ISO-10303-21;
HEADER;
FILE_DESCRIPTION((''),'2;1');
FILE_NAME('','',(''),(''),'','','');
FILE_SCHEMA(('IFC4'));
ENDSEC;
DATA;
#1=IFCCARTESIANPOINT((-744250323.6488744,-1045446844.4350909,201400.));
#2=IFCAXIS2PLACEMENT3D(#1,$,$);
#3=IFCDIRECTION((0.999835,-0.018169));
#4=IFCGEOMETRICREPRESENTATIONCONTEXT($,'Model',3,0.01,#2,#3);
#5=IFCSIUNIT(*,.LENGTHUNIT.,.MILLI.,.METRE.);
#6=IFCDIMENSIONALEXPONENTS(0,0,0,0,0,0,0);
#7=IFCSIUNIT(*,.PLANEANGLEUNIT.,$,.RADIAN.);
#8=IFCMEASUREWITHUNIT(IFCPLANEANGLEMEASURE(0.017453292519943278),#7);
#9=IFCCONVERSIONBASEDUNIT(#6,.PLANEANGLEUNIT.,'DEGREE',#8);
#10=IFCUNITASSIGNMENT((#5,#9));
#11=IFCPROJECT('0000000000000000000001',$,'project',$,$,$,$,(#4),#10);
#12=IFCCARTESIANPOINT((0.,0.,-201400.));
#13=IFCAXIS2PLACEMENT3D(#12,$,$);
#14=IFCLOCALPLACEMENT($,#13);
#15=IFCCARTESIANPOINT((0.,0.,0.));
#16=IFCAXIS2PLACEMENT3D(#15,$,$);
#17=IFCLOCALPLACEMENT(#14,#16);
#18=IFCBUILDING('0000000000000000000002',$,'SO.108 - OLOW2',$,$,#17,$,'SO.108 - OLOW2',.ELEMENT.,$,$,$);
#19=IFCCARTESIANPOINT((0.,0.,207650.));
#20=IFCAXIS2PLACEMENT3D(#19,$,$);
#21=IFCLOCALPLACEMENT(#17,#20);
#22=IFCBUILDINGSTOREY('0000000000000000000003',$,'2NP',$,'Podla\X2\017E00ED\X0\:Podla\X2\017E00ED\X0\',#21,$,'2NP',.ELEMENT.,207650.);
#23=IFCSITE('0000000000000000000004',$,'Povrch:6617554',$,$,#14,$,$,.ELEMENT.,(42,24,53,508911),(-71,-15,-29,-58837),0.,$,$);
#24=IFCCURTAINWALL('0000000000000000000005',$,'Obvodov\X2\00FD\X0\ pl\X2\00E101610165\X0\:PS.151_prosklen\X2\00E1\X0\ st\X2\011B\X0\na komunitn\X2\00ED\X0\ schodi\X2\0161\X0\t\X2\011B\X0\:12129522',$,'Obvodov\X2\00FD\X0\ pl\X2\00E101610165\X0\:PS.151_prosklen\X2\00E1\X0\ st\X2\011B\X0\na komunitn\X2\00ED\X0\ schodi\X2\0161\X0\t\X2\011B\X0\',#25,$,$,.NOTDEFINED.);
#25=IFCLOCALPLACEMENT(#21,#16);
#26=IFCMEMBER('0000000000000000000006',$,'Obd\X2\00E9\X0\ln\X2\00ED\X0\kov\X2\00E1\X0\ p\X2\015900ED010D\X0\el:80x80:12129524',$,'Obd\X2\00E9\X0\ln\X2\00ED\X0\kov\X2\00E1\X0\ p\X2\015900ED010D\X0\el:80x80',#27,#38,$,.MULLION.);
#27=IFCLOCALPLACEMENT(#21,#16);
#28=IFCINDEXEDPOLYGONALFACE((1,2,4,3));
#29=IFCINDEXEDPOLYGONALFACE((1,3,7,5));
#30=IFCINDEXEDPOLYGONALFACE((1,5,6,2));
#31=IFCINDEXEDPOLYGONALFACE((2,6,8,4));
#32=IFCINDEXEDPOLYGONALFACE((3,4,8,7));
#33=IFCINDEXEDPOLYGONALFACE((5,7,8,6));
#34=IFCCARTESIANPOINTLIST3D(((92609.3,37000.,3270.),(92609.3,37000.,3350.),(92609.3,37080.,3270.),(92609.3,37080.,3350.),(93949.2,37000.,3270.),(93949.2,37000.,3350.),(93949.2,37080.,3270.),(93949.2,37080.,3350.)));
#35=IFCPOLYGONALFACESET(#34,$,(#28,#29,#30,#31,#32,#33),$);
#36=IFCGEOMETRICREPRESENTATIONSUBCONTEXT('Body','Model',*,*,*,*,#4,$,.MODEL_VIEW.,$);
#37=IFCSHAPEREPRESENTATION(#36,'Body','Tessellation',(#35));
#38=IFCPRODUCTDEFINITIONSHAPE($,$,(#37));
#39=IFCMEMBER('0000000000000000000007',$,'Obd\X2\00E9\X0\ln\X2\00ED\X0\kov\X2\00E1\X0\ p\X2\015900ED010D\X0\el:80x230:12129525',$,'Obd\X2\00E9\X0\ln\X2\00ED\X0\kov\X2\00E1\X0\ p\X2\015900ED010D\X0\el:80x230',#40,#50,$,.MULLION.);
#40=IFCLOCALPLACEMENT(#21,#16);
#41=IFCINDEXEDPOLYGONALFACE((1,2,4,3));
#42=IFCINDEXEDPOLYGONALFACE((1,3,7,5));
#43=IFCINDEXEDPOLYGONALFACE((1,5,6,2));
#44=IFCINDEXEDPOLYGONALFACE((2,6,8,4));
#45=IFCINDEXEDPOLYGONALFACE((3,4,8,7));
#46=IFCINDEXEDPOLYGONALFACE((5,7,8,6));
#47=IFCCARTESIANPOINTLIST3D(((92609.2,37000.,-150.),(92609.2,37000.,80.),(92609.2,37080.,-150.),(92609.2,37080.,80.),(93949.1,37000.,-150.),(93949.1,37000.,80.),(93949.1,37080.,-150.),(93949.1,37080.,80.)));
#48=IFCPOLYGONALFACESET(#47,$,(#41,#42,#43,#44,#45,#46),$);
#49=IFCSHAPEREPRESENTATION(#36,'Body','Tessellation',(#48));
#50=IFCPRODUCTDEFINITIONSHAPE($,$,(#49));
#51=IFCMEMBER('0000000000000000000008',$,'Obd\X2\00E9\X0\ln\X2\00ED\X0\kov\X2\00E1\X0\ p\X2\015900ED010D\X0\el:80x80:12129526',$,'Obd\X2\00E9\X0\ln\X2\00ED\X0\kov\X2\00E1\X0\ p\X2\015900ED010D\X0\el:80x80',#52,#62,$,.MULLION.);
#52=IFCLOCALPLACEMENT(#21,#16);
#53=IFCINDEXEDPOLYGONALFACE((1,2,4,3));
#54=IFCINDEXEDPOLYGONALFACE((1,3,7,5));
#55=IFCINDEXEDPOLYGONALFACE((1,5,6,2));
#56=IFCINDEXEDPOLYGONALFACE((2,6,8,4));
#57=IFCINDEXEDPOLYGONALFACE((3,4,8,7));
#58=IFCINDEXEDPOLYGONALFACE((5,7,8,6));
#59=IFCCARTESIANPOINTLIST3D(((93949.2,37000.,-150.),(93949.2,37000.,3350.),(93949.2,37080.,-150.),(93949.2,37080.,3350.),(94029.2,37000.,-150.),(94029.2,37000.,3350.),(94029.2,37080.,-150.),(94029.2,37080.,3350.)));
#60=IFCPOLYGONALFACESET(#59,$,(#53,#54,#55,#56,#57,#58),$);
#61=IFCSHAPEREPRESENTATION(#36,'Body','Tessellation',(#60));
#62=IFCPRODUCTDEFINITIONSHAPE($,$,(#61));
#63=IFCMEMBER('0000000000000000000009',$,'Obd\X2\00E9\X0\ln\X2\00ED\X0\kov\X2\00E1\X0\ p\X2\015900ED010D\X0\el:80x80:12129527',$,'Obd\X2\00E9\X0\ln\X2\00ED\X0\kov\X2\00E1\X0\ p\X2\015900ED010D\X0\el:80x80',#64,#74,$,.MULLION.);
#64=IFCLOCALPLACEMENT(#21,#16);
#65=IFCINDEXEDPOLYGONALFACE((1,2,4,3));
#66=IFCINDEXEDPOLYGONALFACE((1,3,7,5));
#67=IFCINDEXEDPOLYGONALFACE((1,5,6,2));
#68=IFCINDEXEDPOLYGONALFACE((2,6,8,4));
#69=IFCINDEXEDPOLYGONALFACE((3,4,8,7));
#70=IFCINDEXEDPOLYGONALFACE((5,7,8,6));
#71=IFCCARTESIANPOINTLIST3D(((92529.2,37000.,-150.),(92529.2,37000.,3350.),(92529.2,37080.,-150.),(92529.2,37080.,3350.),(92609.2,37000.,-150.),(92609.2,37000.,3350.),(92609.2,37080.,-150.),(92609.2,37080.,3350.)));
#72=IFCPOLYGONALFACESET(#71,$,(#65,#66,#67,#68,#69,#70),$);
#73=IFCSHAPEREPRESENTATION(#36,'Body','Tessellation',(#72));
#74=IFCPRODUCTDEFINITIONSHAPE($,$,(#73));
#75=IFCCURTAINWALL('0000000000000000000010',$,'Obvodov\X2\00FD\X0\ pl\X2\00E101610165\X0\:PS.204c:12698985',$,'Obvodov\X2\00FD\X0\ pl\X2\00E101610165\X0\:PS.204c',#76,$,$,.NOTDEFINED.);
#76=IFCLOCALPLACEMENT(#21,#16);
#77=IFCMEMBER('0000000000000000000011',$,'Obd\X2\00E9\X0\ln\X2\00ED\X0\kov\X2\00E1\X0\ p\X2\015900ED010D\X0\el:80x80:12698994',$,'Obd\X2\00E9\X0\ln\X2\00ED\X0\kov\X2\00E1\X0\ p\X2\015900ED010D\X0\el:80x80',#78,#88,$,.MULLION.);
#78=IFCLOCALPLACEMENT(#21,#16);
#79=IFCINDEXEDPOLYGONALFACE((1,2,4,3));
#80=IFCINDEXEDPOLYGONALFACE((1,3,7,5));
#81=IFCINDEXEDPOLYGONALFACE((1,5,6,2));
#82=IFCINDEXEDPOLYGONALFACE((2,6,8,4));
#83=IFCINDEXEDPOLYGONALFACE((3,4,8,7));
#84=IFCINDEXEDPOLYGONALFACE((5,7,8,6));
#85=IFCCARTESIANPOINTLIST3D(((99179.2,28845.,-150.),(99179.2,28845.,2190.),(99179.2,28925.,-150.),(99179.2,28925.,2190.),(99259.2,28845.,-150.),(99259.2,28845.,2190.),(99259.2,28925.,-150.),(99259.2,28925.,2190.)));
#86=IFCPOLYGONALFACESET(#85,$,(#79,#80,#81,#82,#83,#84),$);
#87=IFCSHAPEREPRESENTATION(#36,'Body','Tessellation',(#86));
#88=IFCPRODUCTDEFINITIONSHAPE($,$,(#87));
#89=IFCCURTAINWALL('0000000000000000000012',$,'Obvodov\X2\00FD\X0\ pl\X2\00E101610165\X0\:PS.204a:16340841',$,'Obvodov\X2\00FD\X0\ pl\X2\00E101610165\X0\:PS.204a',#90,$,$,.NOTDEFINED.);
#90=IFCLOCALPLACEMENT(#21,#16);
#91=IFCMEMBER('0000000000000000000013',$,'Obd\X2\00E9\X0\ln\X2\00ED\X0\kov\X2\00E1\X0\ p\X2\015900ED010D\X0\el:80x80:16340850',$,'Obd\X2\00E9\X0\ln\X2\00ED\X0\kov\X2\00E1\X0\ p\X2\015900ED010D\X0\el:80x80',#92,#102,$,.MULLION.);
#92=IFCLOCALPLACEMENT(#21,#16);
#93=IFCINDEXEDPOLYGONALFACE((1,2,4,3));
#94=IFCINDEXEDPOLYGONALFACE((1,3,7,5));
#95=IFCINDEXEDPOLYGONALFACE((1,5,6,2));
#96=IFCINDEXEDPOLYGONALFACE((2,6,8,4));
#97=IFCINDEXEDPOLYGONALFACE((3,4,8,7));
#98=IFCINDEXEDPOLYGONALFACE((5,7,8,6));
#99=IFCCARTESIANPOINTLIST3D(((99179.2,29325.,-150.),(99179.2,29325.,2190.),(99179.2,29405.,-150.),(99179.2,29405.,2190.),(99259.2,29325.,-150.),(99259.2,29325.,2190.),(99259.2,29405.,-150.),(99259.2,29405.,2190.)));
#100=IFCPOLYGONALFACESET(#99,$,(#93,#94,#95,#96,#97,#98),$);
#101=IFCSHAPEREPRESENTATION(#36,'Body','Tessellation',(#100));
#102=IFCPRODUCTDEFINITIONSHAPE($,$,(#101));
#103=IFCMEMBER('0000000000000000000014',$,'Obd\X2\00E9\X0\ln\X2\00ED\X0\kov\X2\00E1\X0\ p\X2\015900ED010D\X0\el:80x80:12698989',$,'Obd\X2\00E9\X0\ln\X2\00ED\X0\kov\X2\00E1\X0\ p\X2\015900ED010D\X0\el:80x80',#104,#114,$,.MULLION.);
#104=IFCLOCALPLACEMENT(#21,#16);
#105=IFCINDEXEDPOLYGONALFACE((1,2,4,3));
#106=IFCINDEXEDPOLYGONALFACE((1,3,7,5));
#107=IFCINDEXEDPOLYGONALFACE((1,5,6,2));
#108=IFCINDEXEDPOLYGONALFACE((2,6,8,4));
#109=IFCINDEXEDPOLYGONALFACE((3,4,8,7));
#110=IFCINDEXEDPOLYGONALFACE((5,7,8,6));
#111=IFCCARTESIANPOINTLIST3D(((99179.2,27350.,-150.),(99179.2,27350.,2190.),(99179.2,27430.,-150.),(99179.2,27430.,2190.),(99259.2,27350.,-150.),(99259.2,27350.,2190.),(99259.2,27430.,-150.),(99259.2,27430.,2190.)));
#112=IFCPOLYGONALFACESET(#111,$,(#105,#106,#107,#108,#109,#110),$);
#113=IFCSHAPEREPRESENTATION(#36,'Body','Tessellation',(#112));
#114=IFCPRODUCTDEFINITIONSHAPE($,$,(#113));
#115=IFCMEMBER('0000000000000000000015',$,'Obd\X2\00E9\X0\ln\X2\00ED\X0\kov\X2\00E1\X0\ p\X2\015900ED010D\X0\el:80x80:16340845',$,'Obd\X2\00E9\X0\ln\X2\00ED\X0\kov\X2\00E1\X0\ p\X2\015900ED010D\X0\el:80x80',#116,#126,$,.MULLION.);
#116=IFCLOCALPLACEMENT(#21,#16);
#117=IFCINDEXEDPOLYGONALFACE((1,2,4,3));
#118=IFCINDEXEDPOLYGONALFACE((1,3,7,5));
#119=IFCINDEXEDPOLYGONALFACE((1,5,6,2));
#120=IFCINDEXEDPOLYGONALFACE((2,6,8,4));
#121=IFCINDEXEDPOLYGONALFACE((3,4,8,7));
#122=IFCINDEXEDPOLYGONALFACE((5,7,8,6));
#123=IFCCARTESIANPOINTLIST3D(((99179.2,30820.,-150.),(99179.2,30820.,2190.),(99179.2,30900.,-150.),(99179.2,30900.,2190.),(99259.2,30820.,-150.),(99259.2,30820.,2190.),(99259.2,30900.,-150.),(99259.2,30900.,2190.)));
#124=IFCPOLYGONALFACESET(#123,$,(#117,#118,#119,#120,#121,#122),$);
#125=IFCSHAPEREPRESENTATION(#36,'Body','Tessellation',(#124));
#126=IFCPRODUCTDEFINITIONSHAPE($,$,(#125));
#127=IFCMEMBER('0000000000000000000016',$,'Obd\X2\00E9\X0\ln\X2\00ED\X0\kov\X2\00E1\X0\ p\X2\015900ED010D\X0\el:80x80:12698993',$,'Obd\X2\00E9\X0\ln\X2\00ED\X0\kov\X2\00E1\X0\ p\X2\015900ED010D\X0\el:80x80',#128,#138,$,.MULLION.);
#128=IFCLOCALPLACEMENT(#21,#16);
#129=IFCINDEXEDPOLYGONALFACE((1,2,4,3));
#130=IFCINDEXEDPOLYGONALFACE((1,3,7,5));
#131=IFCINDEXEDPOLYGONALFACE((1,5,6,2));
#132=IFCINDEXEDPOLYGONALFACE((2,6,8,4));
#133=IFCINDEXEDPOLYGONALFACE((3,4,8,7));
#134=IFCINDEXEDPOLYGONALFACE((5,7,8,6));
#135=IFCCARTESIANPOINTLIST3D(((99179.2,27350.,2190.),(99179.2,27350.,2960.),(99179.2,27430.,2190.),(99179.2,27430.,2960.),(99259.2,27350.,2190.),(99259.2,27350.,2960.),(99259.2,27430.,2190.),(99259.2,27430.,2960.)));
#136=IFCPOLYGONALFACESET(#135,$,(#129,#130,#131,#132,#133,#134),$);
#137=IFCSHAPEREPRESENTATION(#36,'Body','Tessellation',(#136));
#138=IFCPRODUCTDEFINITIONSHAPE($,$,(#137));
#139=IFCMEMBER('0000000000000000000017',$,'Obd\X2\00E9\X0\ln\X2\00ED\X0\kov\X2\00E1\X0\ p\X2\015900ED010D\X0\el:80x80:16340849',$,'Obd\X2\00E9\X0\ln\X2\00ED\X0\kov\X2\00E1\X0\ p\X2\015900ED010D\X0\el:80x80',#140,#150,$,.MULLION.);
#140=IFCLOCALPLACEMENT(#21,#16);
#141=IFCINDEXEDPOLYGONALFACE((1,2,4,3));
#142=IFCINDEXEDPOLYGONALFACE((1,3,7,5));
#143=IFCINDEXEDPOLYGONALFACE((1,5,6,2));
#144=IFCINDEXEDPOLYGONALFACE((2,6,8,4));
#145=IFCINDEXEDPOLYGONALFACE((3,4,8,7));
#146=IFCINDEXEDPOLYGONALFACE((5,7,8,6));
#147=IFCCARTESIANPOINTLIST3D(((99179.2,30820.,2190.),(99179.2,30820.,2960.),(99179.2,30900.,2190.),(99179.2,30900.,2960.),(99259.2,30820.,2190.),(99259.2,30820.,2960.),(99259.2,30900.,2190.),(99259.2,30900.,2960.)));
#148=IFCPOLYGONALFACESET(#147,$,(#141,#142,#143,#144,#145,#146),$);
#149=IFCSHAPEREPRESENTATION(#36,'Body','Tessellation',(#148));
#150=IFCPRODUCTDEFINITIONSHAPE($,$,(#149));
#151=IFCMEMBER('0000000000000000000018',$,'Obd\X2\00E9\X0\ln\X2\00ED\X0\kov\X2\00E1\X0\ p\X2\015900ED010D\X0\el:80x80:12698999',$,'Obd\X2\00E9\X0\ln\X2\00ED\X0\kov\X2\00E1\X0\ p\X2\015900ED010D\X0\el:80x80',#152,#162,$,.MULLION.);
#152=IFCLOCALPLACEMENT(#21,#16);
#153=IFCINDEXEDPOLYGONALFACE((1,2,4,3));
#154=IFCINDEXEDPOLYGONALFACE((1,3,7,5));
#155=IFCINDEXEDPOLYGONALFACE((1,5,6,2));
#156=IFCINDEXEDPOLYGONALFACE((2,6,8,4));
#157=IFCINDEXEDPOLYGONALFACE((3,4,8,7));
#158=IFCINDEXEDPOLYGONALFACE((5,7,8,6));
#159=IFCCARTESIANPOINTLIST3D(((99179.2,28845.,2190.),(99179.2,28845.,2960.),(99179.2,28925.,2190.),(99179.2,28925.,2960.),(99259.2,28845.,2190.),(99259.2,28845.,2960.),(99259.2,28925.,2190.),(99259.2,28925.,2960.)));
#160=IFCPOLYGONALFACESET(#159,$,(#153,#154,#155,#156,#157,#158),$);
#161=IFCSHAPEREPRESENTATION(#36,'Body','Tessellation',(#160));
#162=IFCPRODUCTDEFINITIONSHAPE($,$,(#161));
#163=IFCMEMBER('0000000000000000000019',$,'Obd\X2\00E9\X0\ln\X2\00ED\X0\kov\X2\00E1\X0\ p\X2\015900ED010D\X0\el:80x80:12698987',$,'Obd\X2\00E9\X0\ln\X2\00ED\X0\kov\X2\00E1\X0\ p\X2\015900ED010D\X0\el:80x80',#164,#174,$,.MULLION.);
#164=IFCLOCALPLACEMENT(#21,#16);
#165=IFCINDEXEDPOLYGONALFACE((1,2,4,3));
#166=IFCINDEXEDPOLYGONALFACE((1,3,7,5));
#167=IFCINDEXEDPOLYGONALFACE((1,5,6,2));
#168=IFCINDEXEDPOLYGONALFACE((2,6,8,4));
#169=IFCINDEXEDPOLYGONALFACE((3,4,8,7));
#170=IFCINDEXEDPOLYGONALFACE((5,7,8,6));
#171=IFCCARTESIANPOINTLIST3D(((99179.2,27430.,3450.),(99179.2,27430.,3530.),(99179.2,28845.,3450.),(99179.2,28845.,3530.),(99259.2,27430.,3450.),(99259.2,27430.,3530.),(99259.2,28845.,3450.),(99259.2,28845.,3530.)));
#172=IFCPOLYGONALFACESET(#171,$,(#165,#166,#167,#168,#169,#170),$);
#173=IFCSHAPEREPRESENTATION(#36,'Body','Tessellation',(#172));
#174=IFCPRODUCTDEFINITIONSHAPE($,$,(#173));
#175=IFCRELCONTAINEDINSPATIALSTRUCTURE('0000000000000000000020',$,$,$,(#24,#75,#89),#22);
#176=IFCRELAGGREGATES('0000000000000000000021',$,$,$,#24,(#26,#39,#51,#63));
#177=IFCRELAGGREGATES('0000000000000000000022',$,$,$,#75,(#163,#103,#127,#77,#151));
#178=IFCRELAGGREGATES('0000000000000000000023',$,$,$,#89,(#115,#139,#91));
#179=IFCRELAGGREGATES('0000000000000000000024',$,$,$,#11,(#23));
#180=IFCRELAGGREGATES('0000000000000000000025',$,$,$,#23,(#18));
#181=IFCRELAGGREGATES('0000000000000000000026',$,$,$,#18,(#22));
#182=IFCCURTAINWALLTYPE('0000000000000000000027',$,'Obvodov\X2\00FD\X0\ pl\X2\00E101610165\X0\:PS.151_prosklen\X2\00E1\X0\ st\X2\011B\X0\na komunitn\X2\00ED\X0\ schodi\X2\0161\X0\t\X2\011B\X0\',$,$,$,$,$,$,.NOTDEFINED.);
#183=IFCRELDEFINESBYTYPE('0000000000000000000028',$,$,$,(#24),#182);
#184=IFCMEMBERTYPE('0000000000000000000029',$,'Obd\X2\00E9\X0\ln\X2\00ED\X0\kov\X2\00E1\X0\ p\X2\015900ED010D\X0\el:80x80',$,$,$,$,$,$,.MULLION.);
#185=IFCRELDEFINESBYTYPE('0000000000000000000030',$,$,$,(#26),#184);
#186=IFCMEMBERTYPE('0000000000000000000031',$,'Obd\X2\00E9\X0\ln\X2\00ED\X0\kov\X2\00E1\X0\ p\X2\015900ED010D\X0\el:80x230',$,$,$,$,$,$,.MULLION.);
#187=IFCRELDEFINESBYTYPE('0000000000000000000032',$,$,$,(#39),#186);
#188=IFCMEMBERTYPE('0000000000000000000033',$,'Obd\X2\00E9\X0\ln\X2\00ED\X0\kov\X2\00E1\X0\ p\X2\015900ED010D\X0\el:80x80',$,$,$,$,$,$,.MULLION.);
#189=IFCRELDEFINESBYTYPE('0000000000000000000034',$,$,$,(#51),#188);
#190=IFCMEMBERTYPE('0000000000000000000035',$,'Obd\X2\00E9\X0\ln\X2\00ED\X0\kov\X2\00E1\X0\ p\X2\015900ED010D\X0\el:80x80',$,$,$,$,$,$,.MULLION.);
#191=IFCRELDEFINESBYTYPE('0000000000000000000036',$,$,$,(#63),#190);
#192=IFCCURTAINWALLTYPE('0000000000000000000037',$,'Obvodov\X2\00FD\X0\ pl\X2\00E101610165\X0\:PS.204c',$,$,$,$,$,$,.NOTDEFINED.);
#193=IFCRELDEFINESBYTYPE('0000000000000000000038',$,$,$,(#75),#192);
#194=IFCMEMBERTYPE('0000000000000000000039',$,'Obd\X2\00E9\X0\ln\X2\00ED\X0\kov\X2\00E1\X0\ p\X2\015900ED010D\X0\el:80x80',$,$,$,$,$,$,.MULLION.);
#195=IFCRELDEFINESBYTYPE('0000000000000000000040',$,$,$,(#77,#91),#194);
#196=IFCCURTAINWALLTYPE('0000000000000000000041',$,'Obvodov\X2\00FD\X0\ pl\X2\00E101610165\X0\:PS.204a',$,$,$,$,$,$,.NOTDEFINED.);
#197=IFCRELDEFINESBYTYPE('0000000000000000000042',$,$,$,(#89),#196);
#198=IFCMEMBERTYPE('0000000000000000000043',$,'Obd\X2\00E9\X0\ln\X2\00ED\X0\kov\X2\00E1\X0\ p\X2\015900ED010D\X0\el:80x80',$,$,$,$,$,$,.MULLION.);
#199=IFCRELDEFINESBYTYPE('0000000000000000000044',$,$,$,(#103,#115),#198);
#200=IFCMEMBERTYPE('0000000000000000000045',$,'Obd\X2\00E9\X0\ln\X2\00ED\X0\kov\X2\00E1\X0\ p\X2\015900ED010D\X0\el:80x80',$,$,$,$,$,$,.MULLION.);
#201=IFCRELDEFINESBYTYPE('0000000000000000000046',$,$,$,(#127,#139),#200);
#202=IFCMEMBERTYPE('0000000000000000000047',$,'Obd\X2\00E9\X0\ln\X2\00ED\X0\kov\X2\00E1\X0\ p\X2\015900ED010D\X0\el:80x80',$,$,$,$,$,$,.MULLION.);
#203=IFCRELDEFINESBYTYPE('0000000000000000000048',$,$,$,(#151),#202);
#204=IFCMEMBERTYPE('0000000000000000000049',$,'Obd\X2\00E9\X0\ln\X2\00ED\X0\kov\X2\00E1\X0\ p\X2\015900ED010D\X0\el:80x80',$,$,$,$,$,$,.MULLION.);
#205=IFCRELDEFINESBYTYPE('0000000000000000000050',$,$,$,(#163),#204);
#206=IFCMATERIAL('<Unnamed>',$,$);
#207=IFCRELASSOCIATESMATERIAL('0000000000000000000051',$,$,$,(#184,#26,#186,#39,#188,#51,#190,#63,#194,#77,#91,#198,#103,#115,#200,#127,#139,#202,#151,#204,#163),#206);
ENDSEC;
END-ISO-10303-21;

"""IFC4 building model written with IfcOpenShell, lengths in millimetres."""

from ifc_helpers import new_model, entity, si_unit, converted_unit, direction, frame, origin, place, context, subcontext, project, spatial, indexed_curve, outline, extrude, source, transform, mapped, material, type_object, type_shapes, element, aggregate, save


model = new_model("IFC4")

# Units and contexts
model_context = context("Model", 3, precision=0.01, world=frame((-744250323.6488744, -1045446844.4350909, 201400.0)), true_north=direction((0.999835, -0.018169)))
body_context = subcontext(model_context, "Body", "Model", "MODEL_VIEW")
ifc_project = project(units=[si_unit("LENGTHUNIT", "METRE", prefix="MILLI"), converted_unit("PLANEANGLEUNIT", "DEGREE", entity("IfcPlaneAngleMeasure", 0.017453292519943278), si_unit("PLANEANGLEUNIT", "RADIAN"), dimensions=[0, 0, 0, 0, 0, 0, 0])], contexts=[model_context])

# Site, building, storey
site_placement = place(None, frame((0.0, 0.0, -201400.0)))
site = spatial("IfcSite", under=ifc_project, at=site_placement, Name="Povrch:6617554", CompositionType="ELEMENT", RefLatitude=(42, 24, 53, 508911), RefLongitude=(-71, -15, -29, -58837), RefElevation=0.0)
building_placement = place(site_placement, origin())
building = spatial("IfcBuilding", under=site, at=building_placement, Name="SO.108 - OLOW2", LongName="SO.108 - OLOW2", CompositionType="ELEMENT")
storey_placement = place(building_placement, frame((0.0, 0.0, 207650.0)))
storey = spatial("IfcBuildingStorey", under=building, at=storey_placement, Name="2NP", ObjectType="Podlaží:Podlaží", LongName="2NP", CompositionType="ELEMENT", Elevation=207650.0)

# Curtain wall, members
curtain_wall_type_1 = type_object("IfcCurtainWallType", Name="Obvodový plášť:PS.151_prosklená stěna komunitní schodiště", PredefinedType="NOTDEFINED")
curtain_wall_1_placement = place(storey_placement, frame((0.0, 0.0, -207650.0)))
curtain_wall_1 = element("IfcCurtainWall", 1, at=curtain_wall_1_placement, inside=storey, type_object=curtain_wall_type_1, Name="Obvodový plášť:PS.151_prosklená stěna komunitní schodiště:12129522", ObjectType="Obvodový plášť:PS.151_prosklená stěna komunitní schodiště", PredefinedType="NOTDEFINED")
ifc_material_1 = material(Name="<Unnamed>")
member_type_1 = type_object("IfcMemberType", Name="Obdélníková příčel:80x80", PredefinedType="MULLION", material=ifc_material_1)
shared_shape_1 = source(origin(), body_context, "Body", "SweptSolid", [
    extrude(outline(indexed_curve([(-40.0, -40.0), (40.0, -40.0), (40.0, 40.0), (-40.0, 40.0), (-40.0, -40.0)], self_intersect=False)), frame((-40.0, 0.0, -1339.9), z_axis=(0.0, 0.0, 1.0), x_axis=(-1.0, 0.0, 0.0)), (0.0, 0.0, 1.0), 1339.9),
])
type_shapes(member_type_1, [shared_shape_1])
member_1_placement = place(curtain_wall_1_placement, frame((93949.2, 37040.0, 211000.0), z_axis=(1.0, 0.0, 0.0), x_axis=(0.0, 0.0, 1.0)))
member_1 = element("IfcMember", 2, at=member_1_placement, type_object=member_type_1, material=ifc_material_1, Name="Obdélníková příčel:80x80:12129524", ObjectType="Obdélníková příčel:80x80", PredefinedType="MULLION", context=body_context, shape_type="MappedRepresentation", body=[
    mapped(shared_shape_1, transform((0.0, 0.0, 0.0), scale=1.0)),
])
member_type_2 = type_object("IfcMemberType", Name="Obdélníková příčel:80x230", PredefinedType="MULLION", material=ifc_material_1)
shared_shape_2 = source(origin(), body_context, "Body", "SweptSolid", [
    extrude(outline(indexed_curve([(-115.0, -40.0), (115.0, -40.0), (115.0, 40.0), (-115.0, 40.0), (-115.0, -40.0)], self_intersect=False)), frame((-115.0, 0.0, -1339.9), z_axis=(0.0, 0.0, 1.0), x_axis=(-1.0, 0.0, 0.0)), (0.0, 0.0, 1.0), 1339.9),
])
type_shapes(member_type_2, [shared_shape_2])
member_2_placement = place(curtain_wall_1_placement, frame((92609.2, 37040.0, 207500.0), z_axis=(-1.0, 0.0, 0.0), x_axis=(0.0, 0.0, -1.0)))
member_2 = element("IfcMember", 3, at=member_2_placement, type_object=member_type_2, material=ifc_material_1, Name="Obdélníková příčel:80x230:12129525", ObjectType="Obdélníková příčel:80x230", PredefinedType="MULLION", context=body_context, shape_type="MappedRepresentation", body=[
    mapped(shared_shape_2, transform((0.0, 0.0, 0.0), scale=1.0)),
])
member_type_3 = type_object("IfcMemberType", Name="Obdélníková příčel:80x80", PredefinedType="MULLION", material=ifc_material_1)
shared_shape_3 = source(origin(), body_context, "Body", "SweptSolid", [
    extrude(outline(indexed_curve([(-40.0, -40.0), (40.0, -40.0), (40.0, 40.0), (-40.0, 40.0), (-40.0, -40.0)], self_intersect=False)), frame((-40.0, 0.0, -3500.0), z_axis=(0.0, 0.0, 1.0), x_axis=(-1.0, 0.0, 0.0)), (0.0, 0.0, 1.0), 3500.0),
])
type_shapes(member_type_3, [shared_shape_3])
member_3_placement = place(curtain_wall_1_placement, frame((94029.2, 37040.0, 207500.0), z_axis=(0.0, 0.0, -1.0), x_axis=(1.0, 0.0, 0.0)))
member_3 = element("IfcMember", 4, at=member_3_placement, type_object=member_type_3, material=ifc_material_1, Name="Obdélníková příčel:80x80:12129526", ObjectType="Obdélníková příčel:80x80", PredefinedType="MULLION", context=body_context, shape_type="MappedRepresentation", body=[
    mapped(shared_shape_3, transform((0.0, 0.0, 0.0), scale=1.0)),
])
member_type_4 = type_object("IfcMemberType", Name="Obdélníková příčel:80x80", PredefinedType="MULLION", material=ifc_material_1)
shared_shape_4 = source(origin(), body_context, "Body", "SweptSolid", [
    extrude(outline(indexed_curve([(-40.0, -40.0), (40.0, -40.0), (40.0, 40.0), (-40.0, 40.0), (-40.0, -40.0)], self_intersect=False)), frame((-40.0, 0.0, -3500.0), z_axis=(0.0, 0.0, 1.0), x_axis=(-1.0, 0.0, 0.0)), (0.0, 0.0, 1.0), 3500.0),
])
type_shapes(member_type_4, [shared_shape_4])
member_4_placement = place(curtain_wall_1_placement, frame((92529.2, 37040.0, 211000.0), z_axis=(0.0, 0.0, 1.0), x_axis=(-1.0, 0.0, 0.0)))
member_4 = element("IfcMember", 5, at=member_4_placement, type_object=member_type_4, material=ifc_material_1, Name="Obdélníková příčel:80x80:12129527", ObjectType="Obdélníková příčel:80x80", PredefinedType="MULLION", context=body_context, shape_type="MappedRepresentation", body=[
    mapped(shared_shape_4, transform((0.0, 0.0, 0.0), scale=1.0)),
])

# Curtain walls, members
curtain_wall_type_2 = type_object("IfcCurtainWallType", Name="Obvodový plášť:PS.204c", PredefinedType="NOTDEFINED")
curtain_wall_2_placement = place(storey_placement, frame((0.0, 0.0, -207650.0)))
curtain_wall_2 = element("IfcCurtainWall", 6, at=curtain_wall_2_placement, inside=storey, type_object=curtain_wall_type_2, Name="Obvodový plášť:PS.204c:12698985", ObjectType="Obvodový plášť:PS.204c", PredefinedType="NOTDEFINED")
member_type_5 = type_object("IfcMemberType", Name="Obdélníková příčel:80x80", PredefinedType="MULLION", material=ifc_material_1)
shared_shape_5 = source(origin(), body_context, "Body", "SweptSolid", [
    extrude(outline(indexed_curve([(-40.0, -40.0), (40.0, -40.0), (40.0, 40.0), (-40.0, 40.0), (-40.0, -40.0)], self_intersect=False)), frame((-40.0, 0.0, -2340.0), z_axis=(0.0, 0.0, 1.0), x_axis=(-1.0, 0.0, 0.0)), (0.0, 0.0, 1.0), 2340.0),
])
type_shapes(member_type_5, [shared_shape_5])
member_5_placement = place(curtain_wall_2_placement, frame((99219.2, 28925.0, 209840.0), z_axis=(0.0, 0.0, 1.0), x_axis=(0.0, 1.0, 0.0)))
member_5 = element("IfcMember", 7, at=member_5_placement, type_object=member_type_5, material=ifc_material_1, Name="Obdélníková příčel:80x80:12698994", ObjectType="Obdélníková příčel:80x80", PredefinedType="MULLION", context=body_context, shape_type="MappedRepresentation", body=[
    mapped(shared_shape_5, transform((0.0, 0.0, 0.0), scale=1.0)),
])
curtain_wall_type_3 = type_object("IfcCurtainWallType", Name="Obvodový plášť:PS.204a", PredefinedType="NOTDEFINED")
curtain_wall_3_placement = place(storey_placement, frame((0.0, 0.0, -207650.0)))
curtain_wall_3 = element("IfcCurtainWall", 8, at=curtain_wall_3_placement, inside=storey, type_object=curtain_wall_type_3, Name="Obvodový plášť:PS.204a:16340841", ObjectType="Obvodový plášť:PS.204a", PredefinedType="NOTDEFINED")
member_6_placement = place(curtain_wall_3_placement, frame((99219.2, 29325.0, 209840.0), z_axis=(0.0, 0.0, 1.0), x_axis=(0.0, -1.0, 0.0)))
member_6 = element("IfcMember", 9, at=member_6_placement, type_object=member_type_5, material=ifc_material_1, Name="Obdélníková příčel:80x80:16340850", ObjectType="Obdélníková příčel:80x80", PredefinedType="MULLION", context=body_context, shape_type="MappedRepresentation", body=[
    mapped(shared_shape_5, transform((0.0, 0.0, 0.0), scale=1.0)),
])

# Members
member_type_6 = type_object("IfcMemberType", Name="Obdélníková příčel:80x80", PredefinedType="MULLION", material=ifc_material_1)
shared_shape_6 = source(origin(), body_context, "Body", "SweptSolid", [
    extrude(outline(indexed_curve([(-40.0, -40.0), (40.0, -40.0), (40.0, 40.0), (-40.0, 40.0), (-40.0, -40.0)], self_intersect=False)), frame((-40.0, 0.0, -2340.0), z_axis=(0.0, 0.0, 1.0), x_axis=(-1.0, 0.0, 0.0)), (0.0, 0.0, 1.0), 2340.0),
])
type_shapes(member_type_6, [shared_shape_6])
member_7_placement = place(curtain_wall_2_placement, frame((99219.2, 27350.0, 207500.0), z_axis=(0.0, 0.0, -1.0), x_axis=(0.0, -1.0, 0.0)))
member_7 = element("IfcMember", 10, at=member_7_placement, type_object=member_type_6, material=ifc_material_1, Name="Obdélníková příčel:80x80:12698989", ObjectType="Obdélníková příčel:80x80", PredefinedType="MULLION", context=body_context, shape_type="MappedRepresentation", body=[
    mapped(shared_shape_6, transform((0.0, 0.0, 0.0), scale=1.0)),
])
member_8_placement = place(curtain_wall_3_placement, frame((99219.2, 30900.0, 207500.0), z_axis=(0.0, 0.0, -1.0), x_axis=(0.0, 1.0, 0.0)))
member_8 = element("IfcMember", 11, at=member_8_placement, type_object=member_type_6, material=ifc_material_1, Name="Obdélníková příčel:80x80:16340845", ObjectType="Obdélníková příčel:80x80", PredefinedType="MULLION", context=body_context, shape_type="MappedRepresentation", body=[
    mapped(shared_shape_6, transform((0.0, 0.0, 0.0), scale=1.0)),
])
member_type_7 = type_object("IfcMemberType", Name="Obdélníková příčel:80x80", PredefinedType="MULLION", material=ifc_material_1)
shared_shape_7 = source(origin(), body_context, "Body", "SweptSolid", [
    extrude(outline(indexed_curve([(-40.0, -40.0), (40.0, -40.0), (40.0, 40.0), (-40.0, 40.0), (-40.0, -40.0)], self_intersect=False)), frame((-40.0, 0.0, -770.0), z_axis=(0.0, 0.0, 1.0), x_axis=(-1.0, 0.0, 0.0)), (0.0, 0.0, 1.0), 770.0),
])
type_shapes(member_type_7, [shared_shape_7])
member_9_placement = place(curtain_wall_2_placement, frame((99219.2, 27350.0, 209840.0), z_axis=(0.0, 0.0, -1.0), x_axis=(0.0, -1.0, 0.0)))
member_9 = element("IfcMember", 12, at=member_9_placement, type_object=member_type_7, material=ifc_material_1, Name="Obdélníková příčel:80x80:12698993", ObjectType="Obdélníková příčel:80x80", PredefinedType="MULLION", context=body_context, shape_type="MappedRepresentation", body=[
    mapped(shared_shape_7, transform((0.0, 0.0, 0.0), scale=1.0)),
])
member_10_placement = place(curtain_wall_3_placement, frame((99219.2, 30900.0, 209840.0), z_axis=(0.0, 0.0, -1.0), x_axis=(0.0, 1.0, 0.0)))
member_10 = element("IfcMember", 13, at=member_10_placement, type_object=member_type_7, material=ifc_material_1, Name="Obdélníková příčel:80x80:16340849", ObjectType="Obdélníková příčel:80x80", PredefinedType="MULLION", context=body_context, shape_type="MappedRepresentation", body=[
    mapped(shared_shape_7, transform((0.0, 0.0, 0.0), scale=1.0)),
])
member_type_8 = type_object("IfcMemberType", Name="Obdélníková příčel:80x80", PredefinedType="MULLION", material=ifc_material_1)
shared_shape_8 = source(origin(), body_context, "Body", "SweptSolid", [
    extrude(outline(indexed_curve([(-40.0, -40.0), (40.0, -40.0), (40.0, 40.0), (-40.0, 40.0), (-40.0, -40.0)], self_intersect=False)), frame((-40.0, 0.0, -770.0), z_axis=(0.0, 0.0, 1.0), x_axis=(-1.0, 0.0, 0.0)), (0.0, 0.0, 1.0), 770.0),
])
type_shapes(member_type_8, [shared_shape_8])
member_11_placement = place(curtain_wall_2_placement, frame((99219.2, 28925.0, 210610.0), z_axis=(0.0, 0.0, 1.0), x_axis=(0.0, 1.0, 0.0)))
member_11 = element("IfcMember", 14, at=member_11_placement, type_object=member_type_8, material=ifc_material_1, Name="Obdélníková příčel:80x80:12698999", ObjectType="Obdélníková příčel:80x80", PredefinedType="MULLION", context=body_context, shape_type="MappedRepresentation", body=[
    mapped(shared_shape_8, transform((0.0, 0.0, 0.0), scale=1.0)),
])
member_type_9 = type_object("IfcMemberType", Name="Obdélníková příčel:80x80", PredefinedType="MULLION", material=ifc_material_1)
shared_shape_9 = source(origin(), body_context, "Body", "SweptSolid", [
    extrude(outline(indexed_curve([(-40.0, -40.0), (40.0, -40.0), (40.0, 40.0), (-40.0, 40.0), (-40.0, -40.0)], self_intersect=False)), frame((-40.0, 0.0, -1415.0), z_axis=(0.0, 0.0, 1.0), x_axis=(-1.0, 0.0, 0.0)), (0.0, 0.0, 1.0), 1415.0),
])
type_shapes(member_type_9, [shared_shape_9])
member_12_placement = place(curtain_wall_2_placement, frame((99219.2, 27430.0, 211180.0), z_axis=(0.0, -1.0, 0.0), x_axis=(0.0, 0.0, 1.0)))
member_12 = element("IfcMember", 15, at=member_12_placement, type_object=member_type_9, material=ifc_material_1, Name="Obdélníková příčel:80x80:12698987", ObjectType="Obdélníková příčel:80x80", PredefinedType="MULLION", context=body_context, shape_type="MappedRepresentation", body=[
    mapped(shared_shape_9, transform((0.0, 0.0, 0.0), scale=1.0)),
])

aggregate(curtain_wall_1, [member_1, member_2, member_3, member_4])
aggregate(curtain_wall_2, [member_12, member_7, member_9, member_5, member_11])

aggregate(curtain_wall_3, [member_8, member_10, member_6])

save(model, "model.ifc")
